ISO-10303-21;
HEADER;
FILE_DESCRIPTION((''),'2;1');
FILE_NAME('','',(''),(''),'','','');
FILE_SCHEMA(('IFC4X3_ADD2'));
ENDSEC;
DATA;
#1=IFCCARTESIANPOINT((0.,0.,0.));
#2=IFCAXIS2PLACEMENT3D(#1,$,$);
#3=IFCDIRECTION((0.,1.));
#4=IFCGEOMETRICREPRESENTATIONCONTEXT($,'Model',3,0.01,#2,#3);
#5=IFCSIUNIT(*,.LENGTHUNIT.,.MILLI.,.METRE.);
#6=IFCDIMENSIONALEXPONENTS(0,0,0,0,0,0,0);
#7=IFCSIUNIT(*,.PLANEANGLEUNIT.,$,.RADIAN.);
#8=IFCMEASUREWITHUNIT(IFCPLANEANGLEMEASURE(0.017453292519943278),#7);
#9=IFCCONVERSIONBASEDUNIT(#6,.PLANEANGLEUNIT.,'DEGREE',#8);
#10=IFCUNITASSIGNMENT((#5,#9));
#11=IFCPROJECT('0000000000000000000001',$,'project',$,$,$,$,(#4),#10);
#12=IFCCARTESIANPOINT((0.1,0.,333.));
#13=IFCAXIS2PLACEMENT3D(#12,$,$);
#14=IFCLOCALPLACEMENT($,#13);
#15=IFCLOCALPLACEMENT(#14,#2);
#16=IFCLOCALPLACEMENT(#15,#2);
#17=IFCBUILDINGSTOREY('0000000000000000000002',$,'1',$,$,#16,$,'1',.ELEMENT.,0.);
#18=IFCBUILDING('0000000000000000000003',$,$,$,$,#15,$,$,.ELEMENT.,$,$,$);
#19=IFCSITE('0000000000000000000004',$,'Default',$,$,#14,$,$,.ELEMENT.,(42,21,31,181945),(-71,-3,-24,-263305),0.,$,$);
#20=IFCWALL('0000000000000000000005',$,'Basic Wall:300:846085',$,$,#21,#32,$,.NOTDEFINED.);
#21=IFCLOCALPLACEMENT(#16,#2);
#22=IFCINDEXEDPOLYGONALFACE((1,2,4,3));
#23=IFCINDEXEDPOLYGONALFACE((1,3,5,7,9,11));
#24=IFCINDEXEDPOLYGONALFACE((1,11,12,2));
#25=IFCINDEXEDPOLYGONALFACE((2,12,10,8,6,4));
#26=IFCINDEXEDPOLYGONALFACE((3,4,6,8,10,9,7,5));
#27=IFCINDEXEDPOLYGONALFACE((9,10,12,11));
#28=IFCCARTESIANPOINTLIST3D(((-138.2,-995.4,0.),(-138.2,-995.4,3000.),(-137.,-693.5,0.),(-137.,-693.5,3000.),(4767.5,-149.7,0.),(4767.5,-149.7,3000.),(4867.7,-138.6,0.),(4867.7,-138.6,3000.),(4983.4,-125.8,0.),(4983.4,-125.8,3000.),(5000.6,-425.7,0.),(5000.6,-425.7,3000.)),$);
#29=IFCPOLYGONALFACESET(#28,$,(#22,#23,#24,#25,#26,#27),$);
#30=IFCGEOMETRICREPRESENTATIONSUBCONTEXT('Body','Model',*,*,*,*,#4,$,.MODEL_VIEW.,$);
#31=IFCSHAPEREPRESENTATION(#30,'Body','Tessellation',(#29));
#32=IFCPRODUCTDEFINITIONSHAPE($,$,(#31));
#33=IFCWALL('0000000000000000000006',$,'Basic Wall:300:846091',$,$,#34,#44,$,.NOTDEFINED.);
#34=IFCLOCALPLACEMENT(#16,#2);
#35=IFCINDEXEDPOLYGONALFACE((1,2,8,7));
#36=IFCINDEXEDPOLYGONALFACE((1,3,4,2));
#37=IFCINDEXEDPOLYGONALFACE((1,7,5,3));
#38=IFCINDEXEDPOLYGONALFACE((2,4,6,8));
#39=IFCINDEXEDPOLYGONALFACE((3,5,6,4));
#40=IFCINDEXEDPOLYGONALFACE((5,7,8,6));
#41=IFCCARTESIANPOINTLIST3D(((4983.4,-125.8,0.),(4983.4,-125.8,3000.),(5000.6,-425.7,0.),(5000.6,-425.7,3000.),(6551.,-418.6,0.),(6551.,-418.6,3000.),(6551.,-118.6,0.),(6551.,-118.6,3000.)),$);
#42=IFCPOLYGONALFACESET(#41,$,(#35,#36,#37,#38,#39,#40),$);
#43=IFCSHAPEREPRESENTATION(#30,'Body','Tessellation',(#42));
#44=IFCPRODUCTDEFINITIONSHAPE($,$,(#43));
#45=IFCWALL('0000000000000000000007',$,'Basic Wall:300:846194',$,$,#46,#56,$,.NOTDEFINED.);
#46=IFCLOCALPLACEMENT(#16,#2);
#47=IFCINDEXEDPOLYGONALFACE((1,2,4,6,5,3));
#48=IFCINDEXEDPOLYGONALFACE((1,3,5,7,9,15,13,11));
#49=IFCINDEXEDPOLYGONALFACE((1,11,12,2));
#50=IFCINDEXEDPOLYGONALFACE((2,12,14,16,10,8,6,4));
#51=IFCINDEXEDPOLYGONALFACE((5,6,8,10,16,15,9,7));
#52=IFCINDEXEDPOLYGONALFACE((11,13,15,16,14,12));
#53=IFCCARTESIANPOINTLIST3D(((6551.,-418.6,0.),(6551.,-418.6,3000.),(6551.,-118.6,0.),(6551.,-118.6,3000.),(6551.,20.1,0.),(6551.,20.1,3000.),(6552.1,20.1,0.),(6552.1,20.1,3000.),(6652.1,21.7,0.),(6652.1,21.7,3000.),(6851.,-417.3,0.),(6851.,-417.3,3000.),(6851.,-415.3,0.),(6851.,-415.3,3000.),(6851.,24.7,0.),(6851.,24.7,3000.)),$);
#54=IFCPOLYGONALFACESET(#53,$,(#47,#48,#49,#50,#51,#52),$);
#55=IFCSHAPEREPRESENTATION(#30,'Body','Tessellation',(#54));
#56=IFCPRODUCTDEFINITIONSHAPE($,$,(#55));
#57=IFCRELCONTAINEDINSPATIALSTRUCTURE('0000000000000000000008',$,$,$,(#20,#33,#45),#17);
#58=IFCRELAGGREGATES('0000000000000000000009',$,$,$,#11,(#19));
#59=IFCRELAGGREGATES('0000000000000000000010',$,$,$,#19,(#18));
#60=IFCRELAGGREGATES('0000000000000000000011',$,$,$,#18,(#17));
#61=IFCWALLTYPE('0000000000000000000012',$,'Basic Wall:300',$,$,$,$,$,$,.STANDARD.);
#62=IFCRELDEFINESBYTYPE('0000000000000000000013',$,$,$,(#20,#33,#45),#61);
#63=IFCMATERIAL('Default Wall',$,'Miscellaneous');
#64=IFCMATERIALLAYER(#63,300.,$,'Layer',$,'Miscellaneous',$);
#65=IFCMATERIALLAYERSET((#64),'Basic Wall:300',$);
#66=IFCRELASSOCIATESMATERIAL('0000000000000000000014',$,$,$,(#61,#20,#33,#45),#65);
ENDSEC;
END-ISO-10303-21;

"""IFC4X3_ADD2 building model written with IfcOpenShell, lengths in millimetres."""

from ifc_helpers import new_model, entity, si_unit, converted_unit, direction, frame, origin, place, context, subcontext, project, spatial, polyline, outline, extrude, material, layer, layer_set, type_object, element, save


model = new_model("IFC4X3_ADD2")

# Units and contexts
model_context = context("Model", 3, precision=0.01, world=origin(), true_north=direction((0.0, 1.0)))
body_context = subcontext(model_context, "Body", "Model", "MODEL_VIEW")
ifc_project = project(units=[si_unit("LENGTHUNIT", "METRE", prefix="MILLI"), converted_unit("PLANEANGLEUNIT", "DEGREE", entity("IfcPlaneAngleMeasure", 0.017453292519943278), si_unit("PLANEANGLEUNIT", "RADIAN"), dimensions=[0, 0, 0, 0, 0, 0, 0])], contexts=[model_context])

# Site, building, storey
site_placement = place(None, frame((0.1, 0.0, 333.0)))
site = spatial("IfcSite", under=ifc_project, at=site_placement, Name="Default", CompositionType="ELEMENT", RefLatitude=(42, 21, 31, 181945), RefLongitude=(-71, -3, -24, -263305), RefElevation=0.0)
building_placement = place(site_placement, origin())
building = spatial("IfcBuilding", under=site, at=building_placement, CompositionType="ELEMENT")
storey_placement = place(building_placement, origin())
storey = spatial("IfcBuildingStorey", under=building, at=storey_placement, Name="1", LongName="1", CompositionType="ELEMENT", Elevation=0.0)

# Walls
ifc_material_1 = material(Name="Default Wall", Category="Miscellaneous")
ifc_layer_1 = layer(ifc_material_1, 300.0, Name="Layer", Category="Miscellaneous")
ifc_layer_set_1 = layer_set([ifc_layer_1], Name="Basic Wall:300")
wall_type_1 = type_object("IfcWallType", Name="Basic Wall:300", PredefinedType="STANDARD", material=ifc_layer_set_1)
wall_1_placement = place(storey_placement, frame((4999.9, -274.9, 0.0), z_axis=(0.0, 0.0, 1.0), x_axis=(-0.99391, -0.110193, 0.0)))
element("IfcWall", 1, at=wall_1_placement, inside=storey, type_object=wall_type_1, material=ifc_layer_set_1, Name="Basic Wall:300:846085", PredefinedType="NOTDEFINED", context=body_context, shape_type="SweptSolid", body=[
    extrude(outline(polyline([(5151.7, -150.0), (5186.2, 150.0), (15.9, 150.0), (0.0, -150.0), (116.4, -150.0), (217.2, -150.0), (5151.7, -150.0)])), origin(), (0.0, 0.0, 1.0), 3000.0),
])
wall_2_placement = place(storey_placement, frame((6551.7, -268.6, 0.0), z_axis=(0.0, 0.0, 1.0), x_axis=(-0.99999, -0.004545, 0.0)))
element("IfcWall", 2, at=wall_2_placement, inside=storey, type_object=wall_type_1, material=ifc_layer_set_1, Name="Basic Wall:300:846091", PredefinedType="NOTDEFINED", context=body_context, shape_type="SweptSolid", body=[
    extrude(outline(polyline([(1567.7, -150.0), (1551.8, 150.0), (1.4, 150.0), (0.0, -150.0), (1567.7, -150.0)])), origin(), (0.0, 0.0, 1.0), 3000.0),
])
wall_3_placement = place(storey_placement, frame((6701.0, 24.7, 0.0), z_axis=(0.0, 0.0, 1.0), x_axis=(0.0, -1.0, 0.0)))
element("IfcWall", 3, at=wall_3_placement, inside=storey, type_object=wall_type_1, material=ifc_layer_set_1, Name="Basic Wall:300:846194", PredefinedType="NOTDEFINED", context=body_context, shape_type="SweptSolid", body=[
    extrude(outline(polyline([(443.4, -150.0), (442.0, 150.0), (440.1, 150.0), (0.0, 150.0), (3.1, -48.9), (4.6, -148.9), (4.6, -150.0), (143.4, -150.0), (443.4, -150.0)])), origin(), (0.0, 0.0, 1.0), 3000.0),
])

save(model, "model.ifc")
